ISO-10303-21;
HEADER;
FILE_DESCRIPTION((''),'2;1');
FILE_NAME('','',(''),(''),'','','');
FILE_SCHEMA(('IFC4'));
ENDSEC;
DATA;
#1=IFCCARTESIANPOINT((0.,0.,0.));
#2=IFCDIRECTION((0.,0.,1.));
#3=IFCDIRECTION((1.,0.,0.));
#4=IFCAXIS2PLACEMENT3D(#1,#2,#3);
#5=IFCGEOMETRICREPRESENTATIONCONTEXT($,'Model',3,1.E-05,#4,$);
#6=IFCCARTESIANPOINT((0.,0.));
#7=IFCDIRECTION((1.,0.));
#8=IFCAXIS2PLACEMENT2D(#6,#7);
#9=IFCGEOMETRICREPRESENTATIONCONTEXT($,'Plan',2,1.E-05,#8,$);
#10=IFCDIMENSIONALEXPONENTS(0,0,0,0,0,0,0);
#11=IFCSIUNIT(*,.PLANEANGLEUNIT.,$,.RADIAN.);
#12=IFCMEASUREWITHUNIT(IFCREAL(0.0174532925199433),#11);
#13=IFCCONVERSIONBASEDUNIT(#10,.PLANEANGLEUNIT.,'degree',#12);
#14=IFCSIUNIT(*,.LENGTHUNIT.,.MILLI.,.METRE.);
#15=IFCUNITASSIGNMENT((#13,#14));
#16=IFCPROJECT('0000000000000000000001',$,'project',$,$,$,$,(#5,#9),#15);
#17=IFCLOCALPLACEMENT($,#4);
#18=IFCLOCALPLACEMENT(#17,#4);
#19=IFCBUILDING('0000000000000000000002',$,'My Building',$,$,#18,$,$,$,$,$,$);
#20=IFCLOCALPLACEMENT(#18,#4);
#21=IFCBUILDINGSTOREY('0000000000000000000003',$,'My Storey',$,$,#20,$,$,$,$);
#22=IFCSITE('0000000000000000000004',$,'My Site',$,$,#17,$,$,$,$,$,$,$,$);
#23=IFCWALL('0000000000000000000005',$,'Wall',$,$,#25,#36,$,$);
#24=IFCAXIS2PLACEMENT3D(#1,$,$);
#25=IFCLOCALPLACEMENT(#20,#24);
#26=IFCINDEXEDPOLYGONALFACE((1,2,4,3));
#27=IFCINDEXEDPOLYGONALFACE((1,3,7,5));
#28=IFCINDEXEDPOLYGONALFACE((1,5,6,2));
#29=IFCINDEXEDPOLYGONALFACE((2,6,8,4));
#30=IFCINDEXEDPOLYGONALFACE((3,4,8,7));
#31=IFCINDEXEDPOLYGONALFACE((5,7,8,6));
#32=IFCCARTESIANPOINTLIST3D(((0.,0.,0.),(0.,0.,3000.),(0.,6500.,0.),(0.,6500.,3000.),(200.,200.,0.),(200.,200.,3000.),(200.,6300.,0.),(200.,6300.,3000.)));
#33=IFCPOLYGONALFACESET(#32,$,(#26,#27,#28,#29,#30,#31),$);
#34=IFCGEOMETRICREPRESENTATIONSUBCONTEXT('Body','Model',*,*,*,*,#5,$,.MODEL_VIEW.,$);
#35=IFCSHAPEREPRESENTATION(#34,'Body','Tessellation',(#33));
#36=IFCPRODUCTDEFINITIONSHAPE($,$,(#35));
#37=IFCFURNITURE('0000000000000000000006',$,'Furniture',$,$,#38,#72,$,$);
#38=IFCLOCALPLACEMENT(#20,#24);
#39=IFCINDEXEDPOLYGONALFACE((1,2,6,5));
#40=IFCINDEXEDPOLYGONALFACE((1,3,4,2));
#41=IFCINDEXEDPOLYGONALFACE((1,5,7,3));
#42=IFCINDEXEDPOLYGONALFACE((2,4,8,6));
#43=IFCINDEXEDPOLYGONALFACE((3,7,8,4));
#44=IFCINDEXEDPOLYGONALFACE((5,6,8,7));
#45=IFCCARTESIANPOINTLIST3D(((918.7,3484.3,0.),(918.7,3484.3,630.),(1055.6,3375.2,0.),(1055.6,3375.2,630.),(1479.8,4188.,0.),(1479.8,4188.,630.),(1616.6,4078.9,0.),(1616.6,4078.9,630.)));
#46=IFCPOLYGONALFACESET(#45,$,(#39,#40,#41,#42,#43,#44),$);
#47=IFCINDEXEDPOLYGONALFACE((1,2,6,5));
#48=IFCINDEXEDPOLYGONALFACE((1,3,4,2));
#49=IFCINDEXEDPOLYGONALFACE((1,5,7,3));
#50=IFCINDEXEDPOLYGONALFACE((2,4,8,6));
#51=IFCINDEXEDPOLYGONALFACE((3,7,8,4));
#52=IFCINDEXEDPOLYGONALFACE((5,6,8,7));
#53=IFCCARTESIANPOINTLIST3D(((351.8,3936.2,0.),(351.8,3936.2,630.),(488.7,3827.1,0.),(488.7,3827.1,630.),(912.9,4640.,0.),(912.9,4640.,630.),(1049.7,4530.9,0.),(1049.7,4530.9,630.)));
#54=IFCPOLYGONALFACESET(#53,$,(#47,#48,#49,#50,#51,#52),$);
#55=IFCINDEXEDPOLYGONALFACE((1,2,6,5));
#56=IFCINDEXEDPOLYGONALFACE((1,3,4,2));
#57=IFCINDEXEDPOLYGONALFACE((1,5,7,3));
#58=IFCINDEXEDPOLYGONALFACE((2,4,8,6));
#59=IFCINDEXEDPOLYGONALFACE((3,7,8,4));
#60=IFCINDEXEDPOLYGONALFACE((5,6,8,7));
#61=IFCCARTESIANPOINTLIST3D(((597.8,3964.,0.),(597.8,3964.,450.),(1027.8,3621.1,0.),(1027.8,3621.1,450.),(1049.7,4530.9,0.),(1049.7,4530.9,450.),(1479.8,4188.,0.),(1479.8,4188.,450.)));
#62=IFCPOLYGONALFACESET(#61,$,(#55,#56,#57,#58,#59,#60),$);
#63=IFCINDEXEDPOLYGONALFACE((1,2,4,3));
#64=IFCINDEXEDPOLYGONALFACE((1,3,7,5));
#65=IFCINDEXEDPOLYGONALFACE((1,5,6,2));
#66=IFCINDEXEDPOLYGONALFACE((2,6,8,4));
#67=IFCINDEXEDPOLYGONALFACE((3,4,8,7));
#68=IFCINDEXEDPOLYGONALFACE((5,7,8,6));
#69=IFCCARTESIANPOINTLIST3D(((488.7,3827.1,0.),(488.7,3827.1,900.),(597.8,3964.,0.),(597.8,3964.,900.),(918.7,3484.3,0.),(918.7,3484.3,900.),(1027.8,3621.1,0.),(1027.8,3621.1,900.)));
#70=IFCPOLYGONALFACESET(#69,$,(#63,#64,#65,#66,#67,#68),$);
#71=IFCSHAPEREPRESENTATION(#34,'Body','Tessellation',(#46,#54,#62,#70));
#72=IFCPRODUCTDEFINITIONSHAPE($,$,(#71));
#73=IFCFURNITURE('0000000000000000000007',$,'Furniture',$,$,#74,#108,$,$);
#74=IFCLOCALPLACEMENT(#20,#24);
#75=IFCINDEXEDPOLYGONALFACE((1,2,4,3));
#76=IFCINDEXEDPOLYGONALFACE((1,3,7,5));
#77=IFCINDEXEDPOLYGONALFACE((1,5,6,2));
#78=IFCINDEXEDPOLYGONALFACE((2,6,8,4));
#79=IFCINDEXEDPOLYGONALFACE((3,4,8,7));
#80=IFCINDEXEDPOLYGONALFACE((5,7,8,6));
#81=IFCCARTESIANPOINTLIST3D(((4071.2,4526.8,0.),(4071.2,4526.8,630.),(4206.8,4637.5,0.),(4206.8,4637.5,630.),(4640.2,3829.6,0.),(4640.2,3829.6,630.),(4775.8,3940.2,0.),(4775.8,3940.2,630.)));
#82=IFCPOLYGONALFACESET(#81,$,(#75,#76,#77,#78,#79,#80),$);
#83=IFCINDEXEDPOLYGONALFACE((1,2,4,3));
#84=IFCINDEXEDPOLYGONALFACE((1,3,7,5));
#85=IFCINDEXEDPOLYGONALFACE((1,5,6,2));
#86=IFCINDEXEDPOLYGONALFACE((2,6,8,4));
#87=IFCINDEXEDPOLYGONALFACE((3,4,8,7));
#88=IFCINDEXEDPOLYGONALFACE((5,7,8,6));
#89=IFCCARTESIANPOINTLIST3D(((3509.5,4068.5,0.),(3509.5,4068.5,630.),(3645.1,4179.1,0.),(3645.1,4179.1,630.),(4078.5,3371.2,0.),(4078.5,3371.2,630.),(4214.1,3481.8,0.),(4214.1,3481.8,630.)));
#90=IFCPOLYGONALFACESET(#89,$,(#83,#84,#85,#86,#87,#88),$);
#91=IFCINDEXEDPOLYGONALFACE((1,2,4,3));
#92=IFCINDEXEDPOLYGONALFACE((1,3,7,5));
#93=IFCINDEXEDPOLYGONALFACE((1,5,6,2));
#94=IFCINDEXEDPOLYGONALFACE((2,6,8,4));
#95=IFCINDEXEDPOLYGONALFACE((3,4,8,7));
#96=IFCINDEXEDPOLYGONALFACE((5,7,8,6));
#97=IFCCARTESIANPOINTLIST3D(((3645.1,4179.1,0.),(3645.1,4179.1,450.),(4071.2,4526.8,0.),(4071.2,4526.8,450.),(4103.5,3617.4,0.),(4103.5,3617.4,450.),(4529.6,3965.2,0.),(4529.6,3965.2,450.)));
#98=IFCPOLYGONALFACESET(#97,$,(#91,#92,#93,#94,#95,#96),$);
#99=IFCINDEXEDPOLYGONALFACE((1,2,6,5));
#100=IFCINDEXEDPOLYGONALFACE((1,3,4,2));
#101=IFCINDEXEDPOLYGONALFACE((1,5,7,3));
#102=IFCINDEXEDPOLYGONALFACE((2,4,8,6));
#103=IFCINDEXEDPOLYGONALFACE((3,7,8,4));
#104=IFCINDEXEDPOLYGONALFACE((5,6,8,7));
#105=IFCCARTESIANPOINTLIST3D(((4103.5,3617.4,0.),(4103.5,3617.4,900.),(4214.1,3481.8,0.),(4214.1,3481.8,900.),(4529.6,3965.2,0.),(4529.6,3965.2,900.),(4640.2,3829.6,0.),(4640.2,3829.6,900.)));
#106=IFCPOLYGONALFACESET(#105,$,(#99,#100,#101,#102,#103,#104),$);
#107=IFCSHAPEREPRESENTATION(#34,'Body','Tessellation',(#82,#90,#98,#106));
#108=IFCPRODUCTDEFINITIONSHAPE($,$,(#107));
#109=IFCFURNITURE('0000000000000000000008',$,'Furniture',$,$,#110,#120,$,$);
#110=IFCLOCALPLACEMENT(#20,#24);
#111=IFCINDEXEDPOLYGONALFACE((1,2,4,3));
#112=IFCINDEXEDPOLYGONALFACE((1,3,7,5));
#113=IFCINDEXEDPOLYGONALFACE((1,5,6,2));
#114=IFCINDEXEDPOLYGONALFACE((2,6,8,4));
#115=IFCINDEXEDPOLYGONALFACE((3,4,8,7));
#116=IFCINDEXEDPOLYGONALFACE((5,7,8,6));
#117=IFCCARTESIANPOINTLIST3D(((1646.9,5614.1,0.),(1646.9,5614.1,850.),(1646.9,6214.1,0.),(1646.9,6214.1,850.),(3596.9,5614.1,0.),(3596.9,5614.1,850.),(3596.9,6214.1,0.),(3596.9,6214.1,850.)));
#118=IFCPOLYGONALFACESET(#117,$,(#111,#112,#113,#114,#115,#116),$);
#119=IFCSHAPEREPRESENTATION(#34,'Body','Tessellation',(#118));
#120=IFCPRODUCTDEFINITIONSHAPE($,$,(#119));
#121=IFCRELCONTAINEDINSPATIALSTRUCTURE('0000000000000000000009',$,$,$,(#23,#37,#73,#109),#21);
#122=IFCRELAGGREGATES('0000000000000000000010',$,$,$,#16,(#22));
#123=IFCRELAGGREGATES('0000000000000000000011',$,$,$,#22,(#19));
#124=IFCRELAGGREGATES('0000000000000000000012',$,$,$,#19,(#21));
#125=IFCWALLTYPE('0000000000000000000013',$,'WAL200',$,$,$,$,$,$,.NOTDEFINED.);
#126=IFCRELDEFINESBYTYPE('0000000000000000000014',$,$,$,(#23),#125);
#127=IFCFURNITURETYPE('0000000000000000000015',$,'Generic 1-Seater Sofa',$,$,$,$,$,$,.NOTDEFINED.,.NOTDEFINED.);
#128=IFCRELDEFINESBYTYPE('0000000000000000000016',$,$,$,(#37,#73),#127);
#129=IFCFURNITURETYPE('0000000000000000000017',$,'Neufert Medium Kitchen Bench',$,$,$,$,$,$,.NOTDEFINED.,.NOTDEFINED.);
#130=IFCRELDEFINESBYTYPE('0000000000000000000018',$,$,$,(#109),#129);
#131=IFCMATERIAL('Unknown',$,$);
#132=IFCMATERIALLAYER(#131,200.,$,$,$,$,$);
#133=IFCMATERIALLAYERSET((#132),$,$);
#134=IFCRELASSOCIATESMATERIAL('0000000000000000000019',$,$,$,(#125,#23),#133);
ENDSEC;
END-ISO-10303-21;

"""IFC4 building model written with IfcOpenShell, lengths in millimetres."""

from ifc_helpers import new_model, entity, si_unit, converted_unit, frame, origin_with_axes, origin_2d_with_axis, place, context, subcontext, project, spatial, line, indexed_curve, outline, extrude, clip, halfspace, shape, source, transform, mapped, material, layer, layer_set, layer_usage, type_object, type_shapes, element, save


model = new_model("IFC4")

# Units and contexts
model_context = context("Model", 3, precision=1e-05, world=origin_with_axes())
plan_context = context("Plan", 2, precision=1e-05, world=origin_2d_with_axis())
body_context_1 = subcontext(model_context, "Body", "Model", "MODEL_VIEW")
body_context_2 = subcontext(plan_context, "Body", "Plan", "PLAN_VIEW")
ifc_project = project(units=[converted_unit("PLANEANGLEUNIT", "degree", entity("IfcReal", 0.0174532925199433), si_unit("PLANEANGLEUNIT", "RADIAN"), dimensions=[0, 0, 0, 0, 0, 0, 0]), si_unit("LENGTHUNIT", "METRE", prefix="MILLI")], contexts=[model_context, plan_context])

# Site, building, storey
site_placement = place(None, origin_with_axes())
site = spatial("IfcSite", under=ifc_project, at=site_placement, Name="My Site")
building_placement = place(site_placement, origin_with_axes())
building = spatial("IfcBuilding", under=site, at=building_placement, Name="My Building")
storey_placement = place(building_placement, origin_with_axes())
storey = spatial("IfcBuildingStorey", under=building, at=storey_placement, Name="My Storey")

# Shared definitions
ifc_material = material(Name="Unknown")

# Shared definitions
ifc_layer_1 = layer(ifc_material, 200.0)
ifc_layer_set_1 = layer_set([ifc_layer_1])
wall_type_1 = type_object("IfcWallType", Name="WAL200", PredefinedType="NOTDEFINED", material=ifc_layer_set_1)

# Wall
ifc_layer_usage_1 = layer_usage(ifc_layer_set_1, "AXIS2", "POSITIVE", 0.0)
wall_1_placement = place(storey_placement, frame((0.0, 6500.0, 0.0), z_axis=(0.0, 0.0, 1.0), x_axis=(0.0, -1.0, 0.0)))
element("IfcWall", 1, at=wall_1_placement, inside=storey, type_object=wall_type_1, material=ifc_layer_usage_1, Name="Wall", context=body_context_1, shape_type="Clipping", body=[
    clip(clip(extrude(outline(indexed_curve([(0.0, 0.0), (0.0, 200.0), (6500.0, 200.0), (6500.0, 0.0), (0.0, 0.0)], self_intersect=False)), origin_with_axes(), (0.0, 0.0, 1.0), 3000.0), halfspace(frame((6500.0, 0.0, 0.0), z_axis=(0.707107, 0.707107, 0.0), x_axis=(0.707107, -0.707107, 0.0)), False)), halfspace(frame((0.0, 0.0, 0.0), z_axis=(-0.707107, 0.707107, 0.0), x_axis=(0.707107, 0.707107, 0.0)), False)),
])

# Furniture
furniture_type_1 = type_object("IfcFurnitureType", Name="Generic 1-Seater Sofa", AssemblyPlace="NOTDEFINED", PredefinedType="NOTDEFINED")
shared_shape_1 = source(origin_with_axes(), body_context_1, "Body", "SweptSolid", [
    extrude(outline(indexed_curve([(0.0, 0.0), (175.0, 0.0), (175.0, 900.0), (0.0, 900.0)], segments=[line(1, 2, 3, 4, 1)])), frame((-450.0, -900.0, 0.0), z_axis=(0.0, 0.0, 1.0), x_axis=(1.0, 0.0, 0.0)), (0.0, 0.0, 1.0), 630.0),
    extrude(outline(indexed_curve([(0.0, 0.0), (175.0, 0.0), (175.0, 900.0), (0.0, 900.0)], segments=[line(1, 2, 3, 4, 1)])), frame((275.0, -900.0, 0.0), z_axis=(0.0, 0.0, 1.0), x_axis=(1.0, 0.0, 0.0)), (0.0, 0.0, 1.0), 630.0),
    extrude(outline(indexed_curve([(175.0, 0.0), (725.0, 0.0), (725.0, 725.0), (175.0, 725.0)], segments=[line(1, 2, 3, 4, 1)])), frame((-450.0, -900.0, 0.0), z_axis=(0.0, 0.0, 1.0), x_axis=(1.0, 0.0, 0.0)), (0.0, 0.0, 1.0), 450.0),
    extrude(outline(indexed_curve([(175.0, 725.0), (725.0, 725.0), (725.0, 900.0), (175.0, 900.0)], segments=[line(1, 2, 3, 4, 1)])), frame((-450.0, -900.0, 0.0), z_axis=(0.0, 0.0, 1.0), x_axis=(1.0, 0.0, 0.0)), (0.0, 0.0, 1.0), 900.0),
])
shared_shape_2 = source(origin_with_axes(), body_context_2, "Body", "Curve2D", [
    entity("IfcIndexedPolyCurve", entity("IfcCartesianPointList2D", [[-450.0, -900.0], [-275.0, -900.0], [-275.0, 0.0], [-450.0, 0.0]]), [entity("IfcLineIndex", [1, 2, 3, 4, 1])]),
    entity("IfcIndexedPolyCurve", entity("IfcCartesianPointList2D", [[275.0, -900.0], [450.0, -900.0], [450.0, 0.0], [275.0, 0.0]]), [entity("IfcLineIndex", [1, 2, 3, 4, 1])]),
    entity("IfcIndexedPolyCurve", entity("IfcCartesianPointList2D", [[-275.0, -900.0], [275.0, -900.0], [275.0, -175.0], [-275.0, -175.0]]), [entity("IfcLineIndex", [1, 2, 3, 4, 1])]),
    entity("IfcIndexedPolyCurve", entity("IfcCartesianPointList2D", [[-275.0, -175.0], [275.0, -175.0], [275.0, 0.0], [-275.0, 0.0]]), [entity("IfcLineIndex", [1, 2, 3, 4, 1])]),
])
type_shapes(furniture_type_1, [shared_shape_1, shared_shape_2])
for number, where, z_axis, x_axis, name in (
    (2, (703.7, 3655.7, 0.0), (0.0, 0.0, 1.0), (-0.78193, 0.623366, 0.0), "Furniture"),
    (3, (4427.2, 3655.7, 0.0), (0.0, 0.0, 1.0), (-0.774748, -0.63227, 0.0), "Furniture"),
):
    element("IfcFurniture", number, at=place(storey_placement, frame(where, z_axis=z_axis, x_axis=x_axis)), inside=storey, type_object=furniture_type_1, Name=name, shapes=[
        shape(body_context_1, "Body", "MappedRepresentation", [mapped(shared_shape_1, transform((0.0, 0.0, 0.0), x_axis=(1.0, 0.0, 0.0), y_axis=(0.0, 1.0, 0.0), z_axis=(0.0, 0.0, 1.0), scale=1.0))]),
        shape(body_context_2, "Body", "MappedRepresentation", [mapped(shared_shape_2, transform((0.0, 0.0, 0.0), x_axis=(1.0, 0.0, 0.0), y_axis=(0.0, 1.0, 0.0), z_axis=(0.0, 0.0, 1.0), scale=1.0))]),
    ])
furniture_type_2 = type_object("IfcFurnitureType", Name="Neufert Medium Kitchen Bench", AssemblyPlace="NOTDEFINED", PredefinedType="NOTDEFINED")
shared_shape_3 = source(origin_with_axes(), body_context_1, "Body", "SweptSolid", [
    extrude(outline(indexed_curve([(0.0, 0.0), (1950.0, 0.0), (1950.0, 600.0), (0.0, 600.0)], segments=[line(1, 2, 3, 4, 1)])), origin_with_axes(), (0.0, 0.0, 1.0), 850.0),
])
shared_shape_4 = source(origin_with_axes(), body_context_2, "Body", "Curve2D", [
    entity("IfcIndexedPolyCurve", entity("IfcCartesianPointList2D", [[0.0, 0.0], [1950.0, 0.0], [1950.0, 600.0], [0.0, 600.0]]), [entity("IfcLineIndex", [1, 2, 3, 4, 1])]),
])
type_shapes(furniture_type_2, [shared_shape_3, shared_shape_4])
furniture_1_placement = place(storey_placement, frame((1646.9, 5614.1, 0.0), z_axis=(0.0, 0.0, 1.0), x_axis=(1.0, 0.0, 0.0)))
element("IfcFurniture", 4, at=furniture_1_placement, inside=storey, type_object=furniture_type_2, Name="Furniture", shapes=[
    shape(body_context_1, "Body", "MappedRepresentation", [mapped(shared_shape_3, transform((0.0, 0.0, 0.0), x_axis=(1.0, 0.0, 0.0), y_axis=(0.0, 1.0, 0.0), z_axis=(0.0, 0.0, 1.0), scale=1.0))]),
    shape(body_context_2, "Body", "MappedRepresentation", [mapped(shared_shape_4, transform((0.0, 0.0, 0.0), x_axis=(1.0, 0.0, 0.0), y_axis=(0.0, 1.0, 0.0), z_axis=(0.0, 0.0, 1.0), scale=1.0))]),
])

save(model, "model.ifc")
